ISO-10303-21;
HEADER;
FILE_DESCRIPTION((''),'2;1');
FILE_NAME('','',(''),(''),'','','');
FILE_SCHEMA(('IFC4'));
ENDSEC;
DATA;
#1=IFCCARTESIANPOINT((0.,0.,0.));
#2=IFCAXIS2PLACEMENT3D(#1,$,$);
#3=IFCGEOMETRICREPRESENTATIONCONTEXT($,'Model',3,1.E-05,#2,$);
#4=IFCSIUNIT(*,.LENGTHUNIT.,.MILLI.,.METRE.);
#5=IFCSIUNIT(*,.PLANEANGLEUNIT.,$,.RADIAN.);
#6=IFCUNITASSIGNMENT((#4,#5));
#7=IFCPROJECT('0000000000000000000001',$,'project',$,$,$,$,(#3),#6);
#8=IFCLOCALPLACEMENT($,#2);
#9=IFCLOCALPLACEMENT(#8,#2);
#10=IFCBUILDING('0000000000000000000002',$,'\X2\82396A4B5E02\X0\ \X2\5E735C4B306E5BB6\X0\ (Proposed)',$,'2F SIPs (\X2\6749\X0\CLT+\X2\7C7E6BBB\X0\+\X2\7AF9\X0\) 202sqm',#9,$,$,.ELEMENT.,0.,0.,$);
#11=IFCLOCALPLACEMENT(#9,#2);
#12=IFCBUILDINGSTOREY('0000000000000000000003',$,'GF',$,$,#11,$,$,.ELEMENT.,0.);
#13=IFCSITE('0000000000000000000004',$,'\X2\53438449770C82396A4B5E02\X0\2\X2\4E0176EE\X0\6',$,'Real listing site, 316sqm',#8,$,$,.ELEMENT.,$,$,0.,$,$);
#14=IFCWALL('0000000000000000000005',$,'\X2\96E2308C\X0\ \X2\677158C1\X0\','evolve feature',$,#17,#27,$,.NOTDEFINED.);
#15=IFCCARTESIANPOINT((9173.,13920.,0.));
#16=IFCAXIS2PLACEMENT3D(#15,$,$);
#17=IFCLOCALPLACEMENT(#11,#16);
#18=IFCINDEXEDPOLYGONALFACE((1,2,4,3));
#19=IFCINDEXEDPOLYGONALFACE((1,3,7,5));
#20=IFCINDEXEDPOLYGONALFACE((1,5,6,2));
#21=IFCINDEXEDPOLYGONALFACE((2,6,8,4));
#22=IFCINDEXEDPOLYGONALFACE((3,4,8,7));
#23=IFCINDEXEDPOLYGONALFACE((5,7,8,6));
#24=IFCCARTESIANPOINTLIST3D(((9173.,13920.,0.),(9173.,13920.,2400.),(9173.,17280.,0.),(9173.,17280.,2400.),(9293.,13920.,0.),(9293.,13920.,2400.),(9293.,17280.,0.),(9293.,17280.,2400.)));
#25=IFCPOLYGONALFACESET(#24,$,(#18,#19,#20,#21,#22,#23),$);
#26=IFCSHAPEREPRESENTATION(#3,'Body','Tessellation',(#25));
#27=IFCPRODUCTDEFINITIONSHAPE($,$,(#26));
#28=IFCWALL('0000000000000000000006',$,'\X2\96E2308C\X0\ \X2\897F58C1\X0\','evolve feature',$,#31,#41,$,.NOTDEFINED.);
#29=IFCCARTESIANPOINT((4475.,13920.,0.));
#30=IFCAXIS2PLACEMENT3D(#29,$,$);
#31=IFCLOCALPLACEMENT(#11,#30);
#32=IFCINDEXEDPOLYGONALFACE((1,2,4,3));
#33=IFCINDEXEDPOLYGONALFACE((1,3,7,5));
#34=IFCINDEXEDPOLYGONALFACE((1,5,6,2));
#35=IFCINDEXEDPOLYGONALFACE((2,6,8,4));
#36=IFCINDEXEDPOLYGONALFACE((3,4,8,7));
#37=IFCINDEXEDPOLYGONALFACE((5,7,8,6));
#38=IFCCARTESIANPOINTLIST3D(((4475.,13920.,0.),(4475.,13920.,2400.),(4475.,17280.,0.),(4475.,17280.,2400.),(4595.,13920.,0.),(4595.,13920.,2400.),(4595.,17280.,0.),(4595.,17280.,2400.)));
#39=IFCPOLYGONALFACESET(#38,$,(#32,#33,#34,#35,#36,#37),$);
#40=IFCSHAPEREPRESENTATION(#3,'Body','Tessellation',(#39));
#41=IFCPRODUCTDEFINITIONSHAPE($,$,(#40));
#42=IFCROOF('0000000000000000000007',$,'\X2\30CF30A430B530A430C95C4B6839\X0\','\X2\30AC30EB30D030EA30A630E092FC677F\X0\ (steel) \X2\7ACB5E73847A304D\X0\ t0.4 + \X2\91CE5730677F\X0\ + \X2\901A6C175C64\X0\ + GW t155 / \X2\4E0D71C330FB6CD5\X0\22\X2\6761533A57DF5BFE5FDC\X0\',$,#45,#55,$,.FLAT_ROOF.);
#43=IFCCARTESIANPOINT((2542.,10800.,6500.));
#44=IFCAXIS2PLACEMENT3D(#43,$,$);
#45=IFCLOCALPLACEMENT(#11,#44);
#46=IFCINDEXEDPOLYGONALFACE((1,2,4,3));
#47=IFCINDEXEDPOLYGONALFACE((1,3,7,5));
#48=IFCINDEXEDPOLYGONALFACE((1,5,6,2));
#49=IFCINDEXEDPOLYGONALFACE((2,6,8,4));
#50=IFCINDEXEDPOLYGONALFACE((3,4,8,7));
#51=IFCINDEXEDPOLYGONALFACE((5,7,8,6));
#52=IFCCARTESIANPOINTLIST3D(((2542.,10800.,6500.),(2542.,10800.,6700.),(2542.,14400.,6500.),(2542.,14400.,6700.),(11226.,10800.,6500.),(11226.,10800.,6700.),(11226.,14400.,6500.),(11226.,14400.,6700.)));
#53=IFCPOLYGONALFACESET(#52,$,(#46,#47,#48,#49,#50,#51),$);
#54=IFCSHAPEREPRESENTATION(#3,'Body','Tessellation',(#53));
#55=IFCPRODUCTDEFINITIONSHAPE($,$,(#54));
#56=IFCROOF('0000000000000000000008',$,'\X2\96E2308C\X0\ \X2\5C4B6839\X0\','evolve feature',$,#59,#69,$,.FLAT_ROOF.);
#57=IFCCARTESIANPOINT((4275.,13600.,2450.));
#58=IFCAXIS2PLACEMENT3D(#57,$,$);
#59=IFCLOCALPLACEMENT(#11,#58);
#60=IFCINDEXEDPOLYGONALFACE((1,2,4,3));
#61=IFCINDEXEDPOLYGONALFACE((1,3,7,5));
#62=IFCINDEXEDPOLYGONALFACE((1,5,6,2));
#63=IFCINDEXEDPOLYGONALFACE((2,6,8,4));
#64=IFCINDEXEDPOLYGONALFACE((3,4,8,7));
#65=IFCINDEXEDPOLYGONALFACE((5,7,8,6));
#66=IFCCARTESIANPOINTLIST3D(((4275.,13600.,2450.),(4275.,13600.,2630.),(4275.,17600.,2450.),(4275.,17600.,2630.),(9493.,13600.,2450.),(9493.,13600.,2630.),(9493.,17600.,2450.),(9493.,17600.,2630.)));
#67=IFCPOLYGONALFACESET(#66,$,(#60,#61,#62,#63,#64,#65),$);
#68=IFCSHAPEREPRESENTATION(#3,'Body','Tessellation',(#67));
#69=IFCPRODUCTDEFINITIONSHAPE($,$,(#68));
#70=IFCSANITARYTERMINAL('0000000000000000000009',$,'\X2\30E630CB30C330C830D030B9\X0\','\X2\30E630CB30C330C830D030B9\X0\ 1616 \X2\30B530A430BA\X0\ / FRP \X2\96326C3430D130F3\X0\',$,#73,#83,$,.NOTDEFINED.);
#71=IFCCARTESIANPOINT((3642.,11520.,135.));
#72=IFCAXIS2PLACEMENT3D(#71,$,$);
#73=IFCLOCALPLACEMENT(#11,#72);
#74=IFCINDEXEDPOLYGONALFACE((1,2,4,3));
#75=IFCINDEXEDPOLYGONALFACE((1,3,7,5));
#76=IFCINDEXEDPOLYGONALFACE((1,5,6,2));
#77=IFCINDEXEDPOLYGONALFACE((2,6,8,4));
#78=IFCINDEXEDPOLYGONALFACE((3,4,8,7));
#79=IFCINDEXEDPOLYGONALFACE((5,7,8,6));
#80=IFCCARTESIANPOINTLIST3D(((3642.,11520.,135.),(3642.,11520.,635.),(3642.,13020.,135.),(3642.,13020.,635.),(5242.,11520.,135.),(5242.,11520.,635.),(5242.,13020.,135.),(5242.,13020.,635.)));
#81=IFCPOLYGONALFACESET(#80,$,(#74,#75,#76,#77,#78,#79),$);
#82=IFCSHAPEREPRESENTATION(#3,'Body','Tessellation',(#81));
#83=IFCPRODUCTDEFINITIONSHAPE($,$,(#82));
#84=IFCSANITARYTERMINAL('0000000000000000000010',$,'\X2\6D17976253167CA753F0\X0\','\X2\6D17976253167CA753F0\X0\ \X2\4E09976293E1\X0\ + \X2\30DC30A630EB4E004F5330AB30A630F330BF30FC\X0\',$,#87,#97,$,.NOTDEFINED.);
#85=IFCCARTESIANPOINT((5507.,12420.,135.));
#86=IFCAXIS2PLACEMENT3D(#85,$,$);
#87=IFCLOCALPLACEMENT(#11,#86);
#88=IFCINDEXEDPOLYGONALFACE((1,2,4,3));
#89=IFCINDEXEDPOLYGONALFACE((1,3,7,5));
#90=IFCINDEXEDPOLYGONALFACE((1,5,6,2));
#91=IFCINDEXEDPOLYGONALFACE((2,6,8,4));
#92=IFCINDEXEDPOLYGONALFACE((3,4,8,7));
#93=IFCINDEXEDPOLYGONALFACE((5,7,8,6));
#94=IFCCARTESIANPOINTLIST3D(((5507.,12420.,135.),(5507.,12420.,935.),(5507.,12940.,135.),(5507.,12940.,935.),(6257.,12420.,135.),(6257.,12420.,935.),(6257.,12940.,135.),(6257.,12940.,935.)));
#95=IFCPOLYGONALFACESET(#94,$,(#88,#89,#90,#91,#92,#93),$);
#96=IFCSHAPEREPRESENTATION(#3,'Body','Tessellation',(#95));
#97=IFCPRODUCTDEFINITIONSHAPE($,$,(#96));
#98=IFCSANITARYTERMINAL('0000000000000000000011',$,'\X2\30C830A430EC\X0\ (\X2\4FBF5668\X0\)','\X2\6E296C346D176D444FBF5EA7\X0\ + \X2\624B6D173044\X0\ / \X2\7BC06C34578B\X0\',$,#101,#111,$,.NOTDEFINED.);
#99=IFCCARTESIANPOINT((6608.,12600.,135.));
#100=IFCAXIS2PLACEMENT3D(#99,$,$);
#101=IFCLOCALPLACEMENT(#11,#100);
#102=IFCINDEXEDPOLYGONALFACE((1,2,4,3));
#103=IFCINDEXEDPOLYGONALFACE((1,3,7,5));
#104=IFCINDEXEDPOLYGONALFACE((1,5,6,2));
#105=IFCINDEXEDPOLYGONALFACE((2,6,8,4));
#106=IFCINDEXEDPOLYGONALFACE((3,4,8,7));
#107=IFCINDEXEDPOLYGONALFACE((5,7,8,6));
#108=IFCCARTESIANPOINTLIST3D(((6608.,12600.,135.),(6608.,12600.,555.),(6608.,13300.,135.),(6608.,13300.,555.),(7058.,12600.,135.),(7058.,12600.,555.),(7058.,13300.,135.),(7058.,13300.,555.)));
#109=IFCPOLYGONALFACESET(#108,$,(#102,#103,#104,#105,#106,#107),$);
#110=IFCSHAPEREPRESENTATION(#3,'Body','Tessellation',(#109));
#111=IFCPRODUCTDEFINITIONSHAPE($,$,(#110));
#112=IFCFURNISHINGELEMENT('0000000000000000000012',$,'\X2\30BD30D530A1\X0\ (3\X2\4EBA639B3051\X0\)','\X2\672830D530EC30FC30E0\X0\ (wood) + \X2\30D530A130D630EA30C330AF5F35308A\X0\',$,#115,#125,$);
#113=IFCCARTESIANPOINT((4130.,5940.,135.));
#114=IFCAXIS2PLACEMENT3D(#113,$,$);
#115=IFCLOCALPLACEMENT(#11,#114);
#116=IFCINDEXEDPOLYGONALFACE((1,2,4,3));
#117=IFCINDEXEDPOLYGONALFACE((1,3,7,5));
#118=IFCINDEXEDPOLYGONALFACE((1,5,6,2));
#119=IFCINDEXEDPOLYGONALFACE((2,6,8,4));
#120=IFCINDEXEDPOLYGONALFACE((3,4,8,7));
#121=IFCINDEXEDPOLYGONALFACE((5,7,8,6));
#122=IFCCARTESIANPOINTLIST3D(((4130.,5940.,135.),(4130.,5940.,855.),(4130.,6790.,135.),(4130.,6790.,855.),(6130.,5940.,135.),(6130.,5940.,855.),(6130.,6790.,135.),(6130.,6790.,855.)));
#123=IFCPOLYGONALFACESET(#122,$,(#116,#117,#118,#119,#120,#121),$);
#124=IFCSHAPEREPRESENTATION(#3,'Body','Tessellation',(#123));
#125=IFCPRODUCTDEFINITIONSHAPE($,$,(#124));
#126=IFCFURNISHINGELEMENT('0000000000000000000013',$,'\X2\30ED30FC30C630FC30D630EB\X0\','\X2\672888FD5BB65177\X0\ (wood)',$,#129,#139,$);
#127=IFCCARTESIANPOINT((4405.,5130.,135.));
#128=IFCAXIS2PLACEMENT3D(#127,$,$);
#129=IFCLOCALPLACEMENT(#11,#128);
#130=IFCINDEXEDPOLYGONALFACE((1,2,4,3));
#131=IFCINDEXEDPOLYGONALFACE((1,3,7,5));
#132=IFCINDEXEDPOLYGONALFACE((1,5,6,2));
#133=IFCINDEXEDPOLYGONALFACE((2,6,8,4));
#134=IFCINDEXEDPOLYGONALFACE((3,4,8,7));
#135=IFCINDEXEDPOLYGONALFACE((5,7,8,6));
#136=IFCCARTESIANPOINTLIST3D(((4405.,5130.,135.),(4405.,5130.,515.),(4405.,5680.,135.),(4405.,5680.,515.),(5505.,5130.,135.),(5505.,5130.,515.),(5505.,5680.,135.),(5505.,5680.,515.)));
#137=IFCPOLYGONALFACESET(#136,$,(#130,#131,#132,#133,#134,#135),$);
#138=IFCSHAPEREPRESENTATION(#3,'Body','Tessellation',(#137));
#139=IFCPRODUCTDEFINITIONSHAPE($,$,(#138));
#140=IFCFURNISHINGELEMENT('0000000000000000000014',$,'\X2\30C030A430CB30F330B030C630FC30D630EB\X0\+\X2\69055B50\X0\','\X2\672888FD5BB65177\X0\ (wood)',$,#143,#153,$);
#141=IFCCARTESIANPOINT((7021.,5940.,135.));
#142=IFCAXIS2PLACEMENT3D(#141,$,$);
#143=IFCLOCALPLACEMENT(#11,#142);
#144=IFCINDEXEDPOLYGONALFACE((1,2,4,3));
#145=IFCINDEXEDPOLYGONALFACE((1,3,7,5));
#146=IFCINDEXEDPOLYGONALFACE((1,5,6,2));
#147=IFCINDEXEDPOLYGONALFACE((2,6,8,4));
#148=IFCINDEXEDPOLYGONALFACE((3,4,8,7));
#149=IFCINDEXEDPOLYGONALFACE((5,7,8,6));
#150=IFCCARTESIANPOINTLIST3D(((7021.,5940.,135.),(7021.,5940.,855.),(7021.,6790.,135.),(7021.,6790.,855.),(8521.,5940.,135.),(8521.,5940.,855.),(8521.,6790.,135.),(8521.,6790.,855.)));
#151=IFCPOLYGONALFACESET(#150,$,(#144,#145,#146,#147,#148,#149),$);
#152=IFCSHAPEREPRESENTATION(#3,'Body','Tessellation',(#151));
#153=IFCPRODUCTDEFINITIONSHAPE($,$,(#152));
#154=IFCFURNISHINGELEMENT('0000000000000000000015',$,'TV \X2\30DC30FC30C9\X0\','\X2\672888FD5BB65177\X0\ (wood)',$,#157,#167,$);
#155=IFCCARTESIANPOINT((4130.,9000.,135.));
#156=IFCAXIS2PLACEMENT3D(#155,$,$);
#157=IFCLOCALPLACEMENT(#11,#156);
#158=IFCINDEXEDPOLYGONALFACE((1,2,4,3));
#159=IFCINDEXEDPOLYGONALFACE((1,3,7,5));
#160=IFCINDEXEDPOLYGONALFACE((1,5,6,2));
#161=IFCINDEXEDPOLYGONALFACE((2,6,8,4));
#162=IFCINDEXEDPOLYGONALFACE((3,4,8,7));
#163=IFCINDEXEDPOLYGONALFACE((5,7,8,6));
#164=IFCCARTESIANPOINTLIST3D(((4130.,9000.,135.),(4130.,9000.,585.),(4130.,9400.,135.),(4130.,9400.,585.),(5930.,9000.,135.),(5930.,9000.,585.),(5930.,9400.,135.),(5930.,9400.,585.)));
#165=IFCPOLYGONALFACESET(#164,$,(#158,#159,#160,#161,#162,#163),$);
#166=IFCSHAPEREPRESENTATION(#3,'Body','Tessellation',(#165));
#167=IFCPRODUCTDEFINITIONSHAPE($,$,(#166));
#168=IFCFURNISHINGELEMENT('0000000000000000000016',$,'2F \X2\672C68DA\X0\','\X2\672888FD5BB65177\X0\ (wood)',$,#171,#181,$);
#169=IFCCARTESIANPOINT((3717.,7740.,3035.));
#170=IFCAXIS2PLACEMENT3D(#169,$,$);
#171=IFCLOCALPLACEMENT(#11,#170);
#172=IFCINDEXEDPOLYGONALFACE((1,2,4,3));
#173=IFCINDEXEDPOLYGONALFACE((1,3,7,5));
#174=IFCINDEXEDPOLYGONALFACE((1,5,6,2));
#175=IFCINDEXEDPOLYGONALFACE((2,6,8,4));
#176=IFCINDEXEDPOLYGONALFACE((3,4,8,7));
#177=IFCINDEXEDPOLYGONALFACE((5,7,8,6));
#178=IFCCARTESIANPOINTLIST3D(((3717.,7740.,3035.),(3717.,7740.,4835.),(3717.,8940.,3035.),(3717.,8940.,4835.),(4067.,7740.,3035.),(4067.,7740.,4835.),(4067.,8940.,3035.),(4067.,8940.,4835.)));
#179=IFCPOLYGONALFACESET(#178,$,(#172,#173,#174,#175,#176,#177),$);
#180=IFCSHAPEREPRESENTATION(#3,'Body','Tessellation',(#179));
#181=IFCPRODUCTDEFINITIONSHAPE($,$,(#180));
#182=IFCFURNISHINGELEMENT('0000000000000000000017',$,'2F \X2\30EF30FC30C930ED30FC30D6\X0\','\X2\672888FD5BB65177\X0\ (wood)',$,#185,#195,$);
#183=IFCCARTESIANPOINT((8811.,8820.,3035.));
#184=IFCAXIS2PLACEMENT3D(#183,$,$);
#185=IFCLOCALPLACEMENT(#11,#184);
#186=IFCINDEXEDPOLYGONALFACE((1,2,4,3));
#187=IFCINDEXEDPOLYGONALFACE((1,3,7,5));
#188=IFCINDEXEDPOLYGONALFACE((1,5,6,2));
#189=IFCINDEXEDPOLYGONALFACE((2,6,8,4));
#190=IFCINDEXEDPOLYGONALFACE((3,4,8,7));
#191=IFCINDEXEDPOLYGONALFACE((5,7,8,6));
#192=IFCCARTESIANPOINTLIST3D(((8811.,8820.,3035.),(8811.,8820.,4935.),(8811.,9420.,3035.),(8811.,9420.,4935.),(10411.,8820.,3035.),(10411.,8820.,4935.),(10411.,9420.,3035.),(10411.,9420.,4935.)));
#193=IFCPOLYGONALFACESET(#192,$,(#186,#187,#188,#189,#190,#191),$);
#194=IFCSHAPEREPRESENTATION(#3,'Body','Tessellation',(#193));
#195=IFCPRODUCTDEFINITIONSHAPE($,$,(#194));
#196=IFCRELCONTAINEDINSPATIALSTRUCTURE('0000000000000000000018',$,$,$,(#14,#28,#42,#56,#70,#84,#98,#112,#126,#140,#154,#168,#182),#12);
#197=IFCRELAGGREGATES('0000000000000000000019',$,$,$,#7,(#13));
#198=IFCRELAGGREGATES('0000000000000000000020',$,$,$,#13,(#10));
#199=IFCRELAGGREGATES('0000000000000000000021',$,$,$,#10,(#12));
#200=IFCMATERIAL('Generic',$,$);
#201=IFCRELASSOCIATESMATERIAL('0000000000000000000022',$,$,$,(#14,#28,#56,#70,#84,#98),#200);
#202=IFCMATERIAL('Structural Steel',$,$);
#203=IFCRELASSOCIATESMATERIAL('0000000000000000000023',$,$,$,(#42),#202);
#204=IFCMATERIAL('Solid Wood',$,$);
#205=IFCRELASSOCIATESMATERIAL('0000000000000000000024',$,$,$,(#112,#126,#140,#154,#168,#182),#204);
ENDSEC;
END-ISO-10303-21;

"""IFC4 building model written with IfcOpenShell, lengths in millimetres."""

from ifc_helpers import new_model, si_unit, frame, frame_2d, origin, place, context, project, spatial, rectangle, extrude, material, element, save


model = new_model("IFC4")

# Units and contexts
model_context = context("Model", 3, precision=1e-05, world=origin())
ifc_project = project(units=[si_unit("LENGTHUNIT", "METRE", prefix="MILLI"), si_unit("PLANEANGLEUNIT", "RADIAN")], contexts=[model_context])

# Site, building, storey
site_placement = place(None, origin())
site = spatial("IfcSite", under=ifc_project, at=site_placement, Name="千葉県船橋市2丁目6", ObjectType="Real listing site, 316sqm", CompositionType="ELEMENT", RefElevation=0.0)
building_placement = place(site_placement, origin())
building = spatial("IfcBuilding", under=site, at=building_placement, Name="船橋市 平屋の家 (Proposed)", ObjectType="2F SIPs (杉CLT+籾殻+竹) 202sqm", CompositionType="ELEMENT", ElevationOfRefHeight=0.0, ElevationOfTerrain=0.0)
storey_placement = place(building_placement, origin())
storey = spatial("IfcBuildingStorey", under=building, at=storey_placement, Name="GF", CompositionType="ELEMENT", Elevation=0.0)

# Shared definitions
ifc_material_1 = material(Name="Generic")

# Shared definitions
ifc_material_2 = material(Name="Solid Wood")

# Walls
wall_1_placement = place(storey_placement, frame((9173.0, 13920.0, 0.0)))
element("IfcWall", 1, at=wall_1_placement, inside=storey, material=ifc_material_1, Name="離れ 東壁", Description="evolve feature", PredefinedType="NOTDEFINED", context=model_context, shape_type="SweptSolid", body=[
    extrude(rectangle(XDim=120.0, YDim=3360.0, at=frame_2d((60.0, 1680.0))), frame((9173.0, 13920.0, 0.0)), (0.0, 0.0, 1.0), 2400.0),
])
wall_2_placement = place(storey_placement, frame((4475.0, 13920.0, 0.0)))
element("IfcWall", 2, at=wall_2_placement, inside=storey, material=ifc_material_1, Name="離れ 西壁", Description="evolve feature", PredefinedType="NOTDEFINED", context=model_context, shape_type="SweptSolid", body=[
    extrude(rectangle(XDim=120.0, YDim=3360.0, at=frame_2d((60.0, 1680.0))), frame((4475.0, 13920.0, 0.0)), (0.0, 0.0, 1.0), 2400.0),
])

# Roofs
ifc_material_3 = material(Name="Structural Steel")
roof_1_placement = place(storey_placement, frame((2542.0, 10800.0, 6500.0)))
element("IfcRoof", 3, at=roof_1_placement, inside=storey, material=ifc_material_3, Name="ハイサイド屋根", Description="ガルバリウム鋼板 (steel) 立平葺き t0.4 + 野地板 + 通気層 + GW t155 / 不燃・法22条区域対応", PredefinedType="FLAT_ROOF", context=model_context, shape_type="SweptSolid", body=[
    extrude(rectangle(XDim=8684.0, YDim=3600.0, at=frame_2d((4342.0, 1800.0))), frame((2542.0, 10800.0, 6500.0)), (0.0, 0.0, 1.0), 200.0),
])
roof_2_placement = place(storey_placement, frame((4275.0, 13600.0, 2450.0)))
element("IfcRoof", 4, at=roof_2_placement, inside=storey, material=ifc_material_1, Name="離れ 屋根", Description="evolve feature", PredefinedType="FLAT_ROOF", context=model_context, shape_type="SweptSolid", body=[
    extrude(rectangle(XDim=5218.0, YDim=4000.0, at=frame_2d((2609.0, 2000.0))), frame((4275.0, 13600.0, 2450.0)), (0.0, 0.0, 1.0), 180.0),
])

# Sanitary terminals
sanitary_terminal_1_placement = place(storey_placement, frame((3642.0, 11520.0, 135.0)))
element("IfcSanitaryTerminal", 5, at=sanitary_terminal_1_placement, inside=storey, material=ifc_material_1, Name="ユニットバス", Description="ユニットバス 1616 サイズ / FRP 防水パン", PredefinedType="NOTDEFINED", context=model_context, shape_type="SweptSolid", body=[
    extrude(rectangle(XDim=1600.0, YDim=1500.0, at=frame_2d((800.0, 750.0))), frame((3642.0, 11520.0, 135.0)), (0.0, 0.0, 1.0), 500.0),
])
sanitary_terminal_2_placement = place(storey_placement, frame((5507.0, 12420.0, 135.0)))
element("IfcSanitaryTerminal", 6, at=sanitary_terminal_2_placement, inside=storey, material=ifc_material_1, Name="洗面化粧台", Description="洗面化粧台 三面鏡 + ボウル一体カウンター", PredefinedType="NOTDEFINED", context=model_context, shape_type="SweptSolid", body=[
    extrude(rectangle(XDim=750.0, YDim=520.0, at=frame_2d((375.0, 260.0))), frame((5507.0, 12420.0, 135.0)), (0.0, 0.0, 1.0), 800.0),
])
sanitary_terminal_3_placement = place(storey_placement, frame((6608.0, 12600.0, 135.0)))
element("IfcSanitaryTerminal", 7, at=sanitary_terminal_3_placement, inside=storey, material=ifc_material_1, Name="トイレ (便器)", Description="温水洗浄便座 + 手洗い / 節水型", PredefinedType="NOTDEFINED", context=model_context, shape_type="SweptSolid", body=[
    extrude(rectangle(XDim=450.0, YDim=700.0, at=frame_2d((225.0, 350.0))), frame((6608.0, 12600.0, 135.0)), (0.0, 0.0, 1.0), 420.0),
])

# Furnishing elements
furnishing_1_placement = place(storey_placement, frame((4130.0, 5940.0, 135.0)))
element("IfcFurnishingElement", 8, at=furnishing_1_placement, inside=storey, material=ifc_material_2, Name="ソファ (3人掛け)", Description="木フレーム (wood) + ファブリック張り", context=model_context, shape_type="SweptSolid", body=[
    extrude(rectangle(XDim=2000.0, YDim=850.0, at=frame_2d((1000.0, 425.0))), frame((4130.0, 5940.0, 135.0)), (0.0, 0.0, 1.0), 720.0),
])
furnishing_2_placement = place(storey_placement, frame((4405.0, 5130.0, 135.0)))
element("IfcFurnishingElement", 9, at=furnishing_2_placement, inside=storey, material=ifc_material_2, Name="ローテーブル", Description="木製家具 (wood)", context=model_context, shape_type="SweptSolid", body=[
    extrude(rectangle(XDim=1100.0, YDim=550.0, at=frame_2d((550.0, 275.0))), frame((4405.0, 5130.0, 135.0)), (0.0, 0.0, 1.0), 380.0),
])
furnishing_3_placement = place(storey_placement, frame((7021.0, 5940.0, 135.0)))
element("IfcFurnishingElement", 10, at=furnishing_3_placement, inside=storey, material=ifc_material_2, Name="ダイニングテーブル+椅子", Description="木製家具 (wood)", context=model_context, shape_type="SweptSolid", body=[
    extrude(rectangle(XDim=1500.0, YDim=850.0, at=frame_2d((750.0, 425.0))), frame((7021.0, 5940.0, 135.0)), (0.0, 0.0, 1.0), 720.0),
])
furnishing_4_placement = place(storey_placement, frame((4130.0, 9000.0, 135.0)))
element("IfcFurnishingElement", 11, at=furnishing_4_placement, inside=storey, material=ifc_material_2, Name="TV ボード", Description="木製家具 (wood)", context=model_context, shape_type="SweptSolid", body=[
    extrude(rectangle(XDim=1800.0, YDim=400.0, at=frame_2d((900.0, 200.0))), frame((4130.0, 9000.0, 135.0)), (0.0, 0.0, 1.0), 450.0),
])
furnishing_5_placement = place(storey_placement, frame((3717.0, 7740.0, 3035.0)))
element("IfcFurnishingElement", 12, at=furnishing_5_placement, inside=storey, material=ifc_material_2, Name="2F 本棚", Description="木製家具 (wood)", context=model_context, shape_type="SweptSolid", body=[
    extrude(rectangle(XDim=350.0, YDim=1200.0, at=frame_2d((175.0, 600.0))), frame((3717.0, 7740.0, 3035.0)), (0.0, 0.0, 1.0), 1800.0),
])
furnishing_6_placement = place(storey_placement, frame((8811.0, 8820.0, 3035.0)))
element("IfcFurnishingElement", 13, at=furnishing_6_placement, inside=storey, material=ifc_material_2, Name="2F ワードローブ", Description="木製家具 (wood)", context=model_context, shape_type="SweptSolid", body=[
    extrude(rectangle(XDim=1600.0, YDim=600.0, at=frame_2d((800.0, 300.0))), frame((8811.0, 8820.0, 3035.0)), (0.0, 0.0, 1.0), 1900.0),
])

save(model, "model.ifc")
